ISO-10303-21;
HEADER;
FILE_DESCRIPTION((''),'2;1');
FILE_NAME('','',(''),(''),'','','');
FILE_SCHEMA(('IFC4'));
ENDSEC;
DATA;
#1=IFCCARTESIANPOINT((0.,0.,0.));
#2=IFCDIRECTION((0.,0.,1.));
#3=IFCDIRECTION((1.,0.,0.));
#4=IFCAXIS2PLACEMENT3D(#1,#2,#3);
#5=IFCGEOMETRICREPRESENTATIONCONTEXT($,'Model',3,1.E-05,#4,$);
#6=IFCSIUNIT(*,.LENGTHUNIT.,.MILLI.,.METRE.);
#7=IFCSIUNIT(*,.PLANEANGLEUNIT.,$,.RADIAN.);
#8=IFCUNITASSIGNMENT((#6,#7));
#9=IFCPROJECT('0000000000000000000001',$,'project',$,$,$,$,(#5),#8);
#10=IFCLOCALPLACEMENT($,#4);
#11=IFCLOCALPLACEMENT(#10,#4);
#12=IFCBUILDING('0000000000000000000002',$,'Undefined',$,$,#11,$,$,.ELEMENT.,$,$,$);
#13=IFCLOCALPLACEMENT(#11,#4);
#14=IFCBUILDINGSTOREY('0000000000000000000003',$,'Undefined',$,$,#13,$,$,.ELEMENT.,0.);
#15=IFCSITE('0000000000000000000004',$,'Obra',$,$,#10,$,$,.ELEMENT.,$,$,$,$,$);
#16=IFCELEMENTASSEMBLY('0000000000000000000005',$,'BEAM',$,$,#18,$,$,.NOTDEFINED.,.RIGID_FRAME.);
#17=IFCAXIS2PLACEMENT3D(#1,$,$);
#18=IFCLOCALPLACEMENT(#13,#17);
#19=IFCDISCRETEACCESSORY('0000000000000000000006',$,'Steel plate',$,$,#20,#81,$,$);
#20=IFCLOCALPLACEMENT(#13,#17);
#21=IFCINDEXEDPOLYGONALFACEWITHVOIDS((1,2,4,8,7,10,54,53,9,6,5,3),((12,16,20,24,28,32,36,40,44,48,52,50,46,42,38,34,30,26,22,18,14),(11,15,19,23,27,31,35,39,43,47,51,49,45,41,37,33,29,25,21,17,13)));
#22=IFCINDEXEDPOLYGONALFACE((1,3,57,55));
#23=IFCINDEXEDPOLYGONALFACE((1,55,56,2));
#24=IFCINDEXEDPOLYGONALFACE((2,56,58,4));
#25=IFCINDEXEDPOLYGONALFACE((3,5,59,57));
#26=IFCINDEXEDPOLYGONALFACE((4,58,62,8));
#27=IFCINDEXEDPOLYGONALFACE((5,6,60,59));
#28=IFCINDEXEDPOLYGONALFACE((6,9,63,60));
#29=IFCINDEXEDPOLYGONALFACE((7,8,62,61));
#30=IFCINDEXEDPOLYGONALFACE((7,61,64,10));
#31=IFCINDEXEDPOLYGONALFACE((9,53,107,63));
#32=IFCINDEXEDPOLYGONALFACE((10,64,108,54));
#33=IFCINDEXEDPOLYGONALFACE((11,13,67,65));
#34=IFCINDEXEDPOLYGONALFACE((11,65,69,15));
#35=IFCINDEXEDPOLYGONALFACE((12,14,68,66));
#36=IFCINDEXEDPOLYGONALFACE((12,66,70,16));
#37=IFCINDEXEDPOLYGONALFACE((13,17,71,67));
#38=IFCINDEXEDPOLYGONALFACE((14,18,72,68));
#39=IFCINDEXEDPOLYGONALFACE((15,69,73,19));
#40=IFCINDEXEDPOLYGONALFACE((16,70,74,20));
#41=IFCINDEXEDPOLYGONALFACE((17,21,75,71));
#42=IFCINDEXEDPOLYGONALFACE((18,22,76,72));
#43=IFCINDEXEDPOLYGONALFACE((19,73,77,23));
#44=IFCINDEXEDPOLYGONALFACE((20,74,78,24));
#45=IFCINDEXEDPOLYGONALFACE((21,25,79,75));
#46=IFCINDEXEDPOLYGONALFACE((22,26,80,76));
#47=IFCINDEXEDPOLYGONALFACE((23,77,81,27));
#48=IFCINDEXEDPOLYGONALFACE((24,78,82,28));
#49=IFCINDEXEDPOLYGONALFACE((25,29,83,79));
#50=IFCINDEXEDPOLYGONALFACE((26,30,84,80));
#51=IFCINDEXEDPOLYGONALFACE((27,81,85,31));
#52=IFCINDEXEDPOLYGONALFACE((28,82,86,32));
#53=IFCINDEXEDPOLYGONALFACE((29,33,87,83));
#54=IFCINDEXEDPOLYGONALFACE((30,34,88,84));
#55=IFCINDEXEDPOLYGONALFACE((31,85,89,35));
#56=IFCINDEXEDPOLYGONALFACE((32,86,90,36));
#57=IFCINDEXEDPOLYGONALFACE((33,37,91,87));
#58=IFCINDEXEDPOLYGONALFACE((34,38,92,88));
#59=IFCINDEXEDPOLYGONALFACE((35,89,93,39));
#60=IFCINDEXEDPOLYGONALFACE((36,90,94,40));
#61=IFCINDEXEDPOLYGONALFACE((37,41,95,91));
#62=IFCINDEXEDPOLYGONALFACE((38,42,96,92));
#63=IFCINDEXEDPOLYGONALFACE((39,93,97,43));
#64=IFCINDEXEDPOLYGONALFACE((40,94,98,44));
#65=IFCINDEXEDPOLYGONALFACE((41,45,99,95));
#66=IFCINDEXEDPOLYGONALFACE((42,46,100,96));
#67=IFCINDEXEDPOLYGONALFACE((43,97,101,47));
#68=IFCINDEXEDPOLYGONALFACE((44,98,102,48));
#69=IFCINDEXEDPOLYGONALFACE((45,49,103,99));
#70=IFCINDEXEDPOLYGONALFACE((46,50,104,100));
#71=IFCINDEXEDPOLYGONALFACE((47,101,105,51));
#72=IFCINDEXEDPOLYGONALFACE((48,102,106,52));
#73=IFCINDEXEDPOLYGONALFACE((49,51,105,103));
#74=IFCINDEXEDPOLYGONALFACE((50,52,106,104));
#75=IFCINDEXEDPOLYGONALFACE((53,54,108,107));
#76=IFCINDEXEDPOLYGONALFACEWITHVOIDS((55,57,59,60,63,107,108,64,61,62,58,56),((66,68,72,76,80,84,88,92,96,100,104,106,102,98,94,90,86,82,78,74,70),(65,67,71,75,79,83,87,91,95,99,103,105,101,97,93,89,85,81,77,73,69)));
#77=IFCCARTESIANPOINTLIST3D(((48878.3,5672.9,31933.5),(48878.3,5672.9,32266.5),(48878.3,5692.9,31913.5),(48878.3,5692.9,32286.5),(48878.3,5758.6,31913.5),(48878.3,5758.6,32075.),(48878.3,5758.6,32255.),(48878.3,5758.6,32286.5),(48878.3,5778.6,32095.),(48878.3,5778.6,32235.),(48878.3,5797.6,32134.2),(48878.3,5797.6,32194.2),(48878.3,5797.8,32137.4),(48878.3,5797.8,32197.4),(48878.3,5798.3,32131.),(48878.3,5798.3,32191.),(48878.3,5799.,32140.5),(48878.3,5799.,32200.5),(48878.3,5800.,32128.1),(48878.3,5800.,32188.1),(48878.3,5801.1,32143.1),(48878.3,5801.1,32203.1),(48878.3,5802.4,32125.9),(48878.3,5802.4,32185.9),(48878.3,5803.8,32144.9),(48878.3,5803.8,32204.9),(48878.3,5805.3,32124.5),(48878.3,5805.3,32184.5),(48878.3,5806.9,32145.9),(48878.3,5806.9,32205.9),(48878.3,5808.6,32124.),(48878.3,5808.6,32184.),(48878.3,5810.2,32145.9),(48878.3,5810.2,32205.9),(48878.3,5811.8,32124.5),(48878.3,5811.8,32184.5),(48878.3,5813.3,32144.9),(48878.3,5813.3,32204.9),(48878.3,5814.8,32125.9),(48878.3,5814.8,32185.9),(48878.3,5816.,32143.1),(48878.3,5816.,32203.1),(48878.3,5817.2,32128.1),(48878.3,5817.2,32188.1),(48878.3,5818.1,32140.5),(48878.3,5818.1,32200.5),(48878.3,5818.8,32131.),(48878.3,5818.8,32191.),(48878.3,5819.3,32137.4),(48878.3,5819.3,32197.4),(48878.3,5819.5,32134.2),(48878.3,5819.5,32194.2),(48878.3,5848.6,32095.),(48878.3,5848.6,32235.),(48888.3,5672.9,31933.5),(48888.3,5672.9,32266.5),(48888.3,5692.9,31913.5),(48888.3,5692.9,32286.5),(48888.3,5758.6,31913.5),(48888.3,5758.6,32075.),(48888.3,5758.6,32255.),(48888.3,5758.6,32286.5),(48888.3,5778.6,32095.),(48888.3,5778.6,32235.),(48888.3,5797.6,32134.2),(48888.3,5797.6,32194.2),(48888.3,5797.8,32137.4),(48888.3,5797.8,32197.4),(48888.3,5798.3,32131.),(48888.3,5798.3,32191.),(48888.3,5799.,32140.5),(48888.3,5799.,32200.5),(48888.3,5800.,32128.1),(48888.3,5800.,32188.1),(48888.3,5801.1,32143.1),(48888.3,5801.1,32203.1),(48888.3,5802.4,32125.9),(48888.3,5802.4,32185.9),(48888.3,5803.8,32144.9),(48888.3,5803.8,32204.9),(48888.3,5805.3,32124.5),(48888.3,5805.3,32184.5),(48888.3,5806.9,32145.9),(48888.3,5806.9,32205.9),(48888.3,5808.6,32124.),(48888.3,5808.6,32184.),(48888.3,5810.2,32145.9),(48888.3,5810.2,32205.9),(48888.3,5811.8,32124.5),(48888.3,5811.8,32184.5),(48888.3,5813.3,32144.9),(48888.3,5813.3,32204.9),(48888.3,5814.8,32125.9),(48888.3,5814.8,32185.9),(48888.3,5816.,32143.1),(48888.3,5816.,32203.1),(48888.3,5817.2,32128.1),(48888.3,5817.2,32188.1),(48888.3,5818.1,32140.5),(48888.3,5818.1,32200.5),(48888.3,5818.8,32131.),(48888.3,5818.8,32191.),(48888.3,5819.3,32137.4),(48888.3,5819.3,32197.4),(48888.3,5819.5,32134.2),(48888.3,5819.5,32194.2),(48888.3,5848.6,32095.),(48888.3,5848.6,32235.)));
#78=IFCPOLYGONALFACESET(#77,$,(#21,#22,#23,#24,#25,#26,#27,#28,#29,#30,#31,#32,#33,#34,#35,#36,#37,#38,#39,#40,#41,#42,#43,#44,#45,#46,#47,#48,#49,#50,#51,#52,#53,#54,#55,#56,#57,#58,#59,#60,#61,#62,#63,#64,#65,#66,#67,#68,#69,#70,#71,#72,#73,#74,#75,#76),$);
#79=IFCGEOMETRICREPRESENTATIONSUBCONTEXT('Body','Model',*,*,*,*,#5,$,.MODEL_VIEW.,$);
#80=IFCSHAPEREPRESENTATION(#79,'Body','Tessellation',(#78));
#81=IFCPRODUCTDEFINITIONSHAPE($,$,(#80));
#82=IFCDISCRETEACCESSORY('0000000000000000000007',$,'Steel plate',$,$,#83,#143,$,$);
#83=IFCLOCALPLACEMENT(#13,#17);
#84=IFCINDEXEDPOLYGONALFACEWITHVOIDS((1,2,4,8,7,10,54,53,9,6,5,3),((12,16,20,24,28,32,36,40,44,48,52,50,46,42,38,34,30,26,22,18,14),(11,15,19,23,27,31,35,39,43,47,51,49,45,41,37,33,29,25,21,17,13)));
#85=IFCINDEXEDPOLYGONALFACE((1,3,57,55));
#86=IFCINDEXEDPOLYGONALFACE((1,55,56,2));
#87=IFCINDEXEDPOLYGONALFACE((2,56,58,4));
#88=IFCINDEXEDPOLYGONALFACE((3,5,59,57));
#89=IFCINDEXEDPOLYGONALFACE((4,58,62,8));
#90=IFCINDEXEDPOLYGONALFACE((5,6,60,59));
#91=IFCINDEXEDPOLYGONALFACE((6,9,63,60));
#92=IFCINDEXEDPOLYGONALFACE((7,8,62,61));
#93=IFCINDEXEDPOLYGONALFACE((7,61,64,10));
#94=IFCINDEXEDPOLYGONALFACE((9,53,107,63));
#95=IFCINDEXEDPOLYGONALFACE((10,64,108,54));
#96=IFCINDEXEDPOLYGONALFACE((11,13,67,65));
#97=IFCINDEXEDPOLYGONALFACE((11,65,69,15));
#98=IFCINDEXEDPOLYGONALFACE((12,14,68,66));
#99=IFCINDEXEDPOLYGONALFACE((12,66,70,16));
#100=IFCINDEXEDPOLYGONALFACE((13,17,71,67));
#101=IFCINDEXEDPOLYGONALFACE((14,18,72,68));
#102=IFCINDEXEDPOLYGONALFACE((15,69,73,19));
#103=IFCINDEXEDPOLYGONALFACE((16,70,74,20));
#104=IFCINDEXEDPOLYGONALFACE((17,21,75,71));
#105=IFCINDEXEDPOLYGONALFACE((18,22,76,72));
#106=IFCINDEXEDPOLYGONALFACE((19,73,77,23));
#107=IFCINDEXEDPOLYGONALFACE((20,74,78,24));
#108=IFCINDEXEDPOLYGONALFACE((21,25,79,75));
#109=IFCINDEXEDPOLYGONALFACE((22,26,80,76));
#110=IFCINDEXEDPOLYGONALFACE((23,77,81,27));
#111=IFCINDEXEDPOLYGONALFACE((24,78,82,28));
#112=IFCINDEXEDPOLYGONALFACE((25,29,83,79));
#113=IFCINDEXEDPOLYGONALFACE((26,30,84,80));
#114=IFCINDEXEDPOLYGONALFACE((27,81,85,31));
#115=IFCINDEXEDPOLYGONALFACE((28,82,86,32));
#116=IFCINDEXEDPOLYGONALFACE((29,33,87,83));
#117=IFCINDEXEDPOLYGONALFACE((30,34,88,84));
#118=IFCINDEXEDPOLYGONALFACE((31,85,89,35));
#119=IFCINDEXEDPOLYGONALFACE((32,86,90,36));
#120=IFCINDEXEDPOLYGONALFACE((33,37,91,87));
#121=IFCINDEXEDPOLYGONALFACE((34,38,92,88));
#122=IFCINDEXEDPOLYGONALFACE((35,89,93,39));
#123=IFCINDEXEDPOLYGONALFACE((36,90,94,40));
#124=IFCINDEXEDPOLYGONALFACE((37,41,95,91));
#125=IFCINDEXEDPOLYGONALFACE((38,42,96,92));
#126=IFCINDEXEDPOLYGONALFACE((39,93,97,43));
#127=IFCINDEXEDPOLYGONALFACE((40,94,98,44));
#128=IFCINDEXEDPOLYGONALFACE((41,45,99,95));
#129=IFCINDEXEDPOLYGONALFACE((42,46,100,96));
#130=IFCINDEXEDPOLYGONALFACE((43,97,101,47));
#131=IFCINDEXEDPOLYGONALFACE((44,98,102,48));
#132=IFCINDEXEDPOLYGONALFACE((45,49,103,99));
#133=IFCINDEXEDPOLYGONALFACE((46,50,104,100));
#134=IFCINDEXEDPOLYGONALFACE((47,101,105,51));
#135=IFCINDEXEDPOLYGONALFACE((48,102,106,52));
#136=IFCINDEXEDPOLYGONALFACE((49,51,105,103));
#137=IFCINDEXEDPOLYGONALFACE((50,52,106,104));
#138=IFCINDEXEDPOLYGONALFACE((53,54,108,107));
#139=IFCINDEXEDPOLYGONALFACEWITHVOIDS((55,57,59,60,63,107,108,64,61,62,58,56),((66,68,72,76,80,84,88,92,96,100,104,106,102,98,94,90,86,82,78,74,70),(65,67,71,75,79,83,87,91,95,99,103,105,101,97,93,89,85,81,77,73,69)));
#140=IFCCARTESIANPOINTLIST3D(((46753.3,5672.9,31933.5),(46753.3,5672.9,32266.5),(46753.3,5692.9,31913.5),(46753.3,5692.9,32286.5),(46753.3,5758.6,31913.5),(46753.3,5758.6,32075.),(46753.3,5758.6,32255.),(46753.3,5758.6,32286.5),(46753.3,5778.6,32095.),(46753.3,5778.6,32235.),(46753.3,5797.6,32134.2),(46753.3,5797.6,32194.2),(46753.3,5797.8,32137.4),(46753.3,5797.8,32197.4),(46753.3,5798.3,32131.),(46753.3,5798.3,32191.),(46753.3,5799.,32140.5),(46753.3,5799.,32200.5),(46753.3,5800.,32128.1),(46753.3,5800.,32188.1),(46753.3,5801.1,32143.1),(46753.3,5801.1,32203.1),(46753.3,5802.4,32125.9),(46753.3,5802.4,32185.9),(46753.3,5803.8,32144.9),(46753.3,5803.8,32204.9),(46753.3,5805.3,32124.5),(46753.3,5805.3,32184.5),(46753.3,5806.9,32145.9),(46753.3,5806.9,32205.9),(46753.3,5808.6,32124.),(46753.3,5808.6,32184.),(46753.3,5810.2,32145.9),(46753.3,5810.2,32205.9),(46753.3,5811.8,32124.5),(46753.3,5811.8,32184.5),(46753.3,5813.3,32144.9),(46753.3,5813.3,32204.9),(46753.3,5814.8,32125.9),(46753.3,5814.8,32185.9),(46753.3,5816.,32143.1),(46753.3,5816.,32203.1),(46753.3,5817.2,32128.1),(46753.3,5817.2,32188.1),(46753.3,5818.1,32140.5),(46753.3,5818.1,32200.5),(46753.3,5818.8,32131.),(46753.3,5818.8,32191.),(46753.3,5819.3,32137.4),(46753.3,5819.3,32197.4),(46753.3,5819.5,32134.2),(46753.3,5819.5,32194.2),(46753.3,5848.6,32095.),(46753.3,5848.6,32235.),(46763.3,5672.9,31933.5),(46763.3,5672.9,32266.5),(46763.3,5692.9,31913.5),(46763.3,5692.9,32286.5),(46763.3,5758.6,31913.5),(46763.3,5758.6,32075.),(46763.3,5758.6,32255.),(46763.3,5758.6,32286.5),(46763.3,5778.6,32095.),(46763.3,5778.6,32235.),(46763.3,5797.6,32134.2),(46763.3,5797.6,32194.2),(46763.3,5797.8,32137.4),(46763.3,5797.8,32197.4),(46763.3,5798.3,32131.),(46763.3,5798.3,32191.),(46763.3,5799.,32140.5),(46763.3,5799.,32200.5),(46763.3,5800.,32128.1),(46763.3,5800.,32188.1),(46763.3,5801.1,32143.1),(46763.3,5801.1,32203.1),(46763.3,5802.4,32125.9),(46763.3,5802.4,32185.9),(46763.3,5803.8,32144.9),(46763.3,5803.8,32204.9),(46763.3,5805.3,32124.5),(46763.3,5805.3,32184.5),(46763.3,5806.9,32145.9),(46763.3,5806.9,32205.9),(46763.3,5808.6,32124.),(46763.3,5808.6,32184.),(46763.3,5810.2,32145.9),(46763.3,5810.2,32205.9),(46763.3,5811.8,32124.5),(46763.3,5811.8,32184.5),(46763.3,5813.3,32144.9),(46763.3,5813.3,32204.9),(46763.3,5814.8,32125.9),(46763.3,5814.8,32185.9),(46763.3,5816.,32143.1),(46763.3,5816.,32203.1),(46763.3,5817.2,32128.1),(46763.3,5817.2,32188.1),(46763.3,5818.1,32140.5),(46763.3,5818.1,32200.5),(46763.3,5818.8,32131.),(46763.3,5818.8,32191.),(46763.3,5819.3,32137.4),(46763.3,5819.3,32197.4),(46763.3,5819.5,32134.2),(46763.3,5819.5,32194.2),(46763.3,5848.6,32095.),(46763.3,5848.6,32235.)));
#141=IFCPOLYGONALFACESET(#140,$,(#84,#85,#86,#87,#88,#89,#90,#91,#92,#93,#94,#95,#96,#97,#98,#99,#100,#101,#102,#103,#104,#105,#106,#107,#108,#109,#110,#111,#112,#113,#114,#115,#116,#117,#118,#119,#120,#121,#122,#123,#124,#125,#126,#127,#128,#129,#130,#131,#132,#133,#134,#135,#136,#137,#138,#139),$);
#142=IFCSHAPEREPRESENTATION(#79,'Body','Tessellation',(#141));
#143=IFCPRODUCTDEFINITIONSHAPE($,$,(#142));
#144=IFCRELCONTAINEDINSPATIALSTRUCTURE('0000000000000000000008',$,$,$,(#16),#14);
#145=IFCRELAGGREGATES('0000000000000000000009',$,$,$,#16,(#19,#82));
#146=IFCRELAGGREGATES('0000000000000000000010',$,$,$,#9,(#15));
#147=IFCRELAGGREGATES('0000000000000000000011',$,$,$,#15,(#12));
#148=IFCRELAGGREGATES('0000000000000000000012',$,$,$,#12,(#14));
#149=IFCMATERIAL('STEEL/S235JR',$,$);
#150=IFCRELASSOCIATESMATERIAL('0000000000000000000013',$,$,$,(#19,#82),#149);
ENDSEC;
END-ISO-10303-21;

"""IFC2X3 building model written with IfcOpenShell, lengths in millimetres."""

from ifc_helpers import new_model, si_unit, frame, origin_with_axes, origin_2d_with_axis, place, context, subcontext, project, spatial, polyline, circle, outline, extrude, source, transform, mapped, material, element, aggregate, save


model = new_model("IFC2X3")

# Units and contexts
model_context = context("Model", 3, precision=1e-05, world=origin_with_axes())
body_context = subcontext(model_context, "Body", "Model", "MODEL_VIEW")
ifc_project = project(units=[si_unit("LENGTHUNIT", "METRE", prefix="MILLI"), si_unit("PLANEANGLEUNIT", "RADIAN")], contexts=[model_context])

# Site, building, storey
site_placement = place(None, origin_with_axes())
site = spatial("IfcSite", under=ifc_project, at=site_placement, Name="Obra", CompositionType="ELEMENT")
building_placement = place(site_placement, origin_with_axes())
building = spatial("IfcBuilding", under=site, at=building_placement, Name="Undefined", CompositionType="ELEMENT")
storey_placement = place(building_placement, origin_with_axes())
storey = spatial("IfcBuildingStorey", under=building, at=storey_placement, Name="Undefined", CompositionType="ELEMENT", Elevation=0.0)

# Element assembly
assembly_1_placement = place(storey_placement, origin_with_axes())
assembly_1 = element("IfcElementAssembly", 1, at=assembly_1_placement, inside=storey, Name="BEAM", AssemblyPlace="NOTDEFINED", PredefinedType="RIGID_FRAME")
ifc_material_1 = material(Name="STEEL/S235JR")

# Discrete accessories, openings
discrete_accessory_1_placement = place(assembly_1_placement, frame((48883.3, 5672.9, 31933.5), z_axis=(1.0, 0.0, 0.0), x_axis=(0.0, 0.707107, -0.707107)))
discrete_accessory_1 = element("IfcDiscreteAccessory", 2, at=discrete_accessory_1_placement, material=ifc_material_1, Name="Steel plate", context=body_context, shape_type="SweptSolid", body=[
    extrude(outline(polyline([(0.0, 0.0), (28.3, 0.0), (74.7, 46.5), (-39.5, 160.7), (-39.5, 188.9), (10.0, 238.4), (-89.0, 337.4), (-138.5, 287.9), (-166.7, 287.9), (-189.0, 310.2), (-235.5, 263.8), (-235.5, 235.5), (0.0, 0.0)])), frame((0.0, 0.0, -5.0), z_axis=(0.0, 0.0, 1.0), x_axis=(1.0, 0.0, 0.0)), (0.0, 0.0, 1.0), 10.0),
])
shared_shape_1 = source(origin_with_axes(), body_context, "Body", "SweptSolid", [
    extrude(circle(Radius=11.0, at=origin_2d_with_axis()), frame((0.0, -13.4, 0.0), z_axis=(0.0, 1.0, 0.0), x_axis=(1.0, 0.0, 0.0)), (0.0, 0.0, 1.0), 10.2),
])
opening_1_placement = place(assembly_1_placement, frame((48875.0, 5768.6, 32235.0), z_axis=(0.0, 1.0, 0.0), x_axis=(0.0, 0.0, -1.0)))
element("IfcOpeningElement", 3, at=opening_1_placement, cuts=discrete_accessory_1, ObjectType="Opening", context=body_context, shape_type="MappedRepresentation", body=[
    mapped(shared_shape_1, transform((40.0, 0.0, 40.0))),
    mapped(shared_shape_1, transform((100.0, 0.0, 40.0))),
])
discrete_accessory_2_placement = place(assembly_1_placement, frame((46758.3, 5672.9, 31933.5), z_axis=(1.0, 0.0, 0.0), x_axis=(0.0, 0.707107, -0.707107)))
discrete_accessory_2 = element("IfcDiscreteAccessory", 4, at=discrete_accessory_2_placement, material=ifc_material_1, Name="Steel plate", context=body_context, shape_type="SweptSolid", body=[
    extrude(outline(polyline([(0.0, 0.0), (28.3, 0.0), (74.7, 46.5), (-39.5, 160.7), (-39.5, 188.9), (10.0, 238.4), (-89.0, 337.4), (-138.5, 287.9), (-166.7, 287.9), (-189.0, 310.2), (-235.5, 263.8), (-235.5, 235.5), (0.0, 0.0)])), frame((0.0, 0.0, -5.0), z_axis=(0.0, 0.0, 1.0), x_axis=(1.0, 0.0, 0.0)), (0.0, 0.0, 1.0), 10.0),
])
opening_2_placement = place(assembly_1_placement, frame((46750.0, 5768.6, 32235.0), z_axis=(0.0, 1.0, 0.0), x_axis=(0.0, 0.0, -1.0)))
element("IfcOpeningElement", 5, at=opening_2_placement, cuts=discrete_accessory_2, ObjectType="Opening", context=body_context, shape_type="MappedRepresentation", body=[
    mapped(shared_shape_1, transform((40.0, 0.0, 40.0))),
    mapped(shared_shape_1, transform((100.0, 0.0, 40.0))),
])
aggregate(assembly_1, [discrete_accessory_1, discrete_accessory_2])

save(model, "model.ifc")
